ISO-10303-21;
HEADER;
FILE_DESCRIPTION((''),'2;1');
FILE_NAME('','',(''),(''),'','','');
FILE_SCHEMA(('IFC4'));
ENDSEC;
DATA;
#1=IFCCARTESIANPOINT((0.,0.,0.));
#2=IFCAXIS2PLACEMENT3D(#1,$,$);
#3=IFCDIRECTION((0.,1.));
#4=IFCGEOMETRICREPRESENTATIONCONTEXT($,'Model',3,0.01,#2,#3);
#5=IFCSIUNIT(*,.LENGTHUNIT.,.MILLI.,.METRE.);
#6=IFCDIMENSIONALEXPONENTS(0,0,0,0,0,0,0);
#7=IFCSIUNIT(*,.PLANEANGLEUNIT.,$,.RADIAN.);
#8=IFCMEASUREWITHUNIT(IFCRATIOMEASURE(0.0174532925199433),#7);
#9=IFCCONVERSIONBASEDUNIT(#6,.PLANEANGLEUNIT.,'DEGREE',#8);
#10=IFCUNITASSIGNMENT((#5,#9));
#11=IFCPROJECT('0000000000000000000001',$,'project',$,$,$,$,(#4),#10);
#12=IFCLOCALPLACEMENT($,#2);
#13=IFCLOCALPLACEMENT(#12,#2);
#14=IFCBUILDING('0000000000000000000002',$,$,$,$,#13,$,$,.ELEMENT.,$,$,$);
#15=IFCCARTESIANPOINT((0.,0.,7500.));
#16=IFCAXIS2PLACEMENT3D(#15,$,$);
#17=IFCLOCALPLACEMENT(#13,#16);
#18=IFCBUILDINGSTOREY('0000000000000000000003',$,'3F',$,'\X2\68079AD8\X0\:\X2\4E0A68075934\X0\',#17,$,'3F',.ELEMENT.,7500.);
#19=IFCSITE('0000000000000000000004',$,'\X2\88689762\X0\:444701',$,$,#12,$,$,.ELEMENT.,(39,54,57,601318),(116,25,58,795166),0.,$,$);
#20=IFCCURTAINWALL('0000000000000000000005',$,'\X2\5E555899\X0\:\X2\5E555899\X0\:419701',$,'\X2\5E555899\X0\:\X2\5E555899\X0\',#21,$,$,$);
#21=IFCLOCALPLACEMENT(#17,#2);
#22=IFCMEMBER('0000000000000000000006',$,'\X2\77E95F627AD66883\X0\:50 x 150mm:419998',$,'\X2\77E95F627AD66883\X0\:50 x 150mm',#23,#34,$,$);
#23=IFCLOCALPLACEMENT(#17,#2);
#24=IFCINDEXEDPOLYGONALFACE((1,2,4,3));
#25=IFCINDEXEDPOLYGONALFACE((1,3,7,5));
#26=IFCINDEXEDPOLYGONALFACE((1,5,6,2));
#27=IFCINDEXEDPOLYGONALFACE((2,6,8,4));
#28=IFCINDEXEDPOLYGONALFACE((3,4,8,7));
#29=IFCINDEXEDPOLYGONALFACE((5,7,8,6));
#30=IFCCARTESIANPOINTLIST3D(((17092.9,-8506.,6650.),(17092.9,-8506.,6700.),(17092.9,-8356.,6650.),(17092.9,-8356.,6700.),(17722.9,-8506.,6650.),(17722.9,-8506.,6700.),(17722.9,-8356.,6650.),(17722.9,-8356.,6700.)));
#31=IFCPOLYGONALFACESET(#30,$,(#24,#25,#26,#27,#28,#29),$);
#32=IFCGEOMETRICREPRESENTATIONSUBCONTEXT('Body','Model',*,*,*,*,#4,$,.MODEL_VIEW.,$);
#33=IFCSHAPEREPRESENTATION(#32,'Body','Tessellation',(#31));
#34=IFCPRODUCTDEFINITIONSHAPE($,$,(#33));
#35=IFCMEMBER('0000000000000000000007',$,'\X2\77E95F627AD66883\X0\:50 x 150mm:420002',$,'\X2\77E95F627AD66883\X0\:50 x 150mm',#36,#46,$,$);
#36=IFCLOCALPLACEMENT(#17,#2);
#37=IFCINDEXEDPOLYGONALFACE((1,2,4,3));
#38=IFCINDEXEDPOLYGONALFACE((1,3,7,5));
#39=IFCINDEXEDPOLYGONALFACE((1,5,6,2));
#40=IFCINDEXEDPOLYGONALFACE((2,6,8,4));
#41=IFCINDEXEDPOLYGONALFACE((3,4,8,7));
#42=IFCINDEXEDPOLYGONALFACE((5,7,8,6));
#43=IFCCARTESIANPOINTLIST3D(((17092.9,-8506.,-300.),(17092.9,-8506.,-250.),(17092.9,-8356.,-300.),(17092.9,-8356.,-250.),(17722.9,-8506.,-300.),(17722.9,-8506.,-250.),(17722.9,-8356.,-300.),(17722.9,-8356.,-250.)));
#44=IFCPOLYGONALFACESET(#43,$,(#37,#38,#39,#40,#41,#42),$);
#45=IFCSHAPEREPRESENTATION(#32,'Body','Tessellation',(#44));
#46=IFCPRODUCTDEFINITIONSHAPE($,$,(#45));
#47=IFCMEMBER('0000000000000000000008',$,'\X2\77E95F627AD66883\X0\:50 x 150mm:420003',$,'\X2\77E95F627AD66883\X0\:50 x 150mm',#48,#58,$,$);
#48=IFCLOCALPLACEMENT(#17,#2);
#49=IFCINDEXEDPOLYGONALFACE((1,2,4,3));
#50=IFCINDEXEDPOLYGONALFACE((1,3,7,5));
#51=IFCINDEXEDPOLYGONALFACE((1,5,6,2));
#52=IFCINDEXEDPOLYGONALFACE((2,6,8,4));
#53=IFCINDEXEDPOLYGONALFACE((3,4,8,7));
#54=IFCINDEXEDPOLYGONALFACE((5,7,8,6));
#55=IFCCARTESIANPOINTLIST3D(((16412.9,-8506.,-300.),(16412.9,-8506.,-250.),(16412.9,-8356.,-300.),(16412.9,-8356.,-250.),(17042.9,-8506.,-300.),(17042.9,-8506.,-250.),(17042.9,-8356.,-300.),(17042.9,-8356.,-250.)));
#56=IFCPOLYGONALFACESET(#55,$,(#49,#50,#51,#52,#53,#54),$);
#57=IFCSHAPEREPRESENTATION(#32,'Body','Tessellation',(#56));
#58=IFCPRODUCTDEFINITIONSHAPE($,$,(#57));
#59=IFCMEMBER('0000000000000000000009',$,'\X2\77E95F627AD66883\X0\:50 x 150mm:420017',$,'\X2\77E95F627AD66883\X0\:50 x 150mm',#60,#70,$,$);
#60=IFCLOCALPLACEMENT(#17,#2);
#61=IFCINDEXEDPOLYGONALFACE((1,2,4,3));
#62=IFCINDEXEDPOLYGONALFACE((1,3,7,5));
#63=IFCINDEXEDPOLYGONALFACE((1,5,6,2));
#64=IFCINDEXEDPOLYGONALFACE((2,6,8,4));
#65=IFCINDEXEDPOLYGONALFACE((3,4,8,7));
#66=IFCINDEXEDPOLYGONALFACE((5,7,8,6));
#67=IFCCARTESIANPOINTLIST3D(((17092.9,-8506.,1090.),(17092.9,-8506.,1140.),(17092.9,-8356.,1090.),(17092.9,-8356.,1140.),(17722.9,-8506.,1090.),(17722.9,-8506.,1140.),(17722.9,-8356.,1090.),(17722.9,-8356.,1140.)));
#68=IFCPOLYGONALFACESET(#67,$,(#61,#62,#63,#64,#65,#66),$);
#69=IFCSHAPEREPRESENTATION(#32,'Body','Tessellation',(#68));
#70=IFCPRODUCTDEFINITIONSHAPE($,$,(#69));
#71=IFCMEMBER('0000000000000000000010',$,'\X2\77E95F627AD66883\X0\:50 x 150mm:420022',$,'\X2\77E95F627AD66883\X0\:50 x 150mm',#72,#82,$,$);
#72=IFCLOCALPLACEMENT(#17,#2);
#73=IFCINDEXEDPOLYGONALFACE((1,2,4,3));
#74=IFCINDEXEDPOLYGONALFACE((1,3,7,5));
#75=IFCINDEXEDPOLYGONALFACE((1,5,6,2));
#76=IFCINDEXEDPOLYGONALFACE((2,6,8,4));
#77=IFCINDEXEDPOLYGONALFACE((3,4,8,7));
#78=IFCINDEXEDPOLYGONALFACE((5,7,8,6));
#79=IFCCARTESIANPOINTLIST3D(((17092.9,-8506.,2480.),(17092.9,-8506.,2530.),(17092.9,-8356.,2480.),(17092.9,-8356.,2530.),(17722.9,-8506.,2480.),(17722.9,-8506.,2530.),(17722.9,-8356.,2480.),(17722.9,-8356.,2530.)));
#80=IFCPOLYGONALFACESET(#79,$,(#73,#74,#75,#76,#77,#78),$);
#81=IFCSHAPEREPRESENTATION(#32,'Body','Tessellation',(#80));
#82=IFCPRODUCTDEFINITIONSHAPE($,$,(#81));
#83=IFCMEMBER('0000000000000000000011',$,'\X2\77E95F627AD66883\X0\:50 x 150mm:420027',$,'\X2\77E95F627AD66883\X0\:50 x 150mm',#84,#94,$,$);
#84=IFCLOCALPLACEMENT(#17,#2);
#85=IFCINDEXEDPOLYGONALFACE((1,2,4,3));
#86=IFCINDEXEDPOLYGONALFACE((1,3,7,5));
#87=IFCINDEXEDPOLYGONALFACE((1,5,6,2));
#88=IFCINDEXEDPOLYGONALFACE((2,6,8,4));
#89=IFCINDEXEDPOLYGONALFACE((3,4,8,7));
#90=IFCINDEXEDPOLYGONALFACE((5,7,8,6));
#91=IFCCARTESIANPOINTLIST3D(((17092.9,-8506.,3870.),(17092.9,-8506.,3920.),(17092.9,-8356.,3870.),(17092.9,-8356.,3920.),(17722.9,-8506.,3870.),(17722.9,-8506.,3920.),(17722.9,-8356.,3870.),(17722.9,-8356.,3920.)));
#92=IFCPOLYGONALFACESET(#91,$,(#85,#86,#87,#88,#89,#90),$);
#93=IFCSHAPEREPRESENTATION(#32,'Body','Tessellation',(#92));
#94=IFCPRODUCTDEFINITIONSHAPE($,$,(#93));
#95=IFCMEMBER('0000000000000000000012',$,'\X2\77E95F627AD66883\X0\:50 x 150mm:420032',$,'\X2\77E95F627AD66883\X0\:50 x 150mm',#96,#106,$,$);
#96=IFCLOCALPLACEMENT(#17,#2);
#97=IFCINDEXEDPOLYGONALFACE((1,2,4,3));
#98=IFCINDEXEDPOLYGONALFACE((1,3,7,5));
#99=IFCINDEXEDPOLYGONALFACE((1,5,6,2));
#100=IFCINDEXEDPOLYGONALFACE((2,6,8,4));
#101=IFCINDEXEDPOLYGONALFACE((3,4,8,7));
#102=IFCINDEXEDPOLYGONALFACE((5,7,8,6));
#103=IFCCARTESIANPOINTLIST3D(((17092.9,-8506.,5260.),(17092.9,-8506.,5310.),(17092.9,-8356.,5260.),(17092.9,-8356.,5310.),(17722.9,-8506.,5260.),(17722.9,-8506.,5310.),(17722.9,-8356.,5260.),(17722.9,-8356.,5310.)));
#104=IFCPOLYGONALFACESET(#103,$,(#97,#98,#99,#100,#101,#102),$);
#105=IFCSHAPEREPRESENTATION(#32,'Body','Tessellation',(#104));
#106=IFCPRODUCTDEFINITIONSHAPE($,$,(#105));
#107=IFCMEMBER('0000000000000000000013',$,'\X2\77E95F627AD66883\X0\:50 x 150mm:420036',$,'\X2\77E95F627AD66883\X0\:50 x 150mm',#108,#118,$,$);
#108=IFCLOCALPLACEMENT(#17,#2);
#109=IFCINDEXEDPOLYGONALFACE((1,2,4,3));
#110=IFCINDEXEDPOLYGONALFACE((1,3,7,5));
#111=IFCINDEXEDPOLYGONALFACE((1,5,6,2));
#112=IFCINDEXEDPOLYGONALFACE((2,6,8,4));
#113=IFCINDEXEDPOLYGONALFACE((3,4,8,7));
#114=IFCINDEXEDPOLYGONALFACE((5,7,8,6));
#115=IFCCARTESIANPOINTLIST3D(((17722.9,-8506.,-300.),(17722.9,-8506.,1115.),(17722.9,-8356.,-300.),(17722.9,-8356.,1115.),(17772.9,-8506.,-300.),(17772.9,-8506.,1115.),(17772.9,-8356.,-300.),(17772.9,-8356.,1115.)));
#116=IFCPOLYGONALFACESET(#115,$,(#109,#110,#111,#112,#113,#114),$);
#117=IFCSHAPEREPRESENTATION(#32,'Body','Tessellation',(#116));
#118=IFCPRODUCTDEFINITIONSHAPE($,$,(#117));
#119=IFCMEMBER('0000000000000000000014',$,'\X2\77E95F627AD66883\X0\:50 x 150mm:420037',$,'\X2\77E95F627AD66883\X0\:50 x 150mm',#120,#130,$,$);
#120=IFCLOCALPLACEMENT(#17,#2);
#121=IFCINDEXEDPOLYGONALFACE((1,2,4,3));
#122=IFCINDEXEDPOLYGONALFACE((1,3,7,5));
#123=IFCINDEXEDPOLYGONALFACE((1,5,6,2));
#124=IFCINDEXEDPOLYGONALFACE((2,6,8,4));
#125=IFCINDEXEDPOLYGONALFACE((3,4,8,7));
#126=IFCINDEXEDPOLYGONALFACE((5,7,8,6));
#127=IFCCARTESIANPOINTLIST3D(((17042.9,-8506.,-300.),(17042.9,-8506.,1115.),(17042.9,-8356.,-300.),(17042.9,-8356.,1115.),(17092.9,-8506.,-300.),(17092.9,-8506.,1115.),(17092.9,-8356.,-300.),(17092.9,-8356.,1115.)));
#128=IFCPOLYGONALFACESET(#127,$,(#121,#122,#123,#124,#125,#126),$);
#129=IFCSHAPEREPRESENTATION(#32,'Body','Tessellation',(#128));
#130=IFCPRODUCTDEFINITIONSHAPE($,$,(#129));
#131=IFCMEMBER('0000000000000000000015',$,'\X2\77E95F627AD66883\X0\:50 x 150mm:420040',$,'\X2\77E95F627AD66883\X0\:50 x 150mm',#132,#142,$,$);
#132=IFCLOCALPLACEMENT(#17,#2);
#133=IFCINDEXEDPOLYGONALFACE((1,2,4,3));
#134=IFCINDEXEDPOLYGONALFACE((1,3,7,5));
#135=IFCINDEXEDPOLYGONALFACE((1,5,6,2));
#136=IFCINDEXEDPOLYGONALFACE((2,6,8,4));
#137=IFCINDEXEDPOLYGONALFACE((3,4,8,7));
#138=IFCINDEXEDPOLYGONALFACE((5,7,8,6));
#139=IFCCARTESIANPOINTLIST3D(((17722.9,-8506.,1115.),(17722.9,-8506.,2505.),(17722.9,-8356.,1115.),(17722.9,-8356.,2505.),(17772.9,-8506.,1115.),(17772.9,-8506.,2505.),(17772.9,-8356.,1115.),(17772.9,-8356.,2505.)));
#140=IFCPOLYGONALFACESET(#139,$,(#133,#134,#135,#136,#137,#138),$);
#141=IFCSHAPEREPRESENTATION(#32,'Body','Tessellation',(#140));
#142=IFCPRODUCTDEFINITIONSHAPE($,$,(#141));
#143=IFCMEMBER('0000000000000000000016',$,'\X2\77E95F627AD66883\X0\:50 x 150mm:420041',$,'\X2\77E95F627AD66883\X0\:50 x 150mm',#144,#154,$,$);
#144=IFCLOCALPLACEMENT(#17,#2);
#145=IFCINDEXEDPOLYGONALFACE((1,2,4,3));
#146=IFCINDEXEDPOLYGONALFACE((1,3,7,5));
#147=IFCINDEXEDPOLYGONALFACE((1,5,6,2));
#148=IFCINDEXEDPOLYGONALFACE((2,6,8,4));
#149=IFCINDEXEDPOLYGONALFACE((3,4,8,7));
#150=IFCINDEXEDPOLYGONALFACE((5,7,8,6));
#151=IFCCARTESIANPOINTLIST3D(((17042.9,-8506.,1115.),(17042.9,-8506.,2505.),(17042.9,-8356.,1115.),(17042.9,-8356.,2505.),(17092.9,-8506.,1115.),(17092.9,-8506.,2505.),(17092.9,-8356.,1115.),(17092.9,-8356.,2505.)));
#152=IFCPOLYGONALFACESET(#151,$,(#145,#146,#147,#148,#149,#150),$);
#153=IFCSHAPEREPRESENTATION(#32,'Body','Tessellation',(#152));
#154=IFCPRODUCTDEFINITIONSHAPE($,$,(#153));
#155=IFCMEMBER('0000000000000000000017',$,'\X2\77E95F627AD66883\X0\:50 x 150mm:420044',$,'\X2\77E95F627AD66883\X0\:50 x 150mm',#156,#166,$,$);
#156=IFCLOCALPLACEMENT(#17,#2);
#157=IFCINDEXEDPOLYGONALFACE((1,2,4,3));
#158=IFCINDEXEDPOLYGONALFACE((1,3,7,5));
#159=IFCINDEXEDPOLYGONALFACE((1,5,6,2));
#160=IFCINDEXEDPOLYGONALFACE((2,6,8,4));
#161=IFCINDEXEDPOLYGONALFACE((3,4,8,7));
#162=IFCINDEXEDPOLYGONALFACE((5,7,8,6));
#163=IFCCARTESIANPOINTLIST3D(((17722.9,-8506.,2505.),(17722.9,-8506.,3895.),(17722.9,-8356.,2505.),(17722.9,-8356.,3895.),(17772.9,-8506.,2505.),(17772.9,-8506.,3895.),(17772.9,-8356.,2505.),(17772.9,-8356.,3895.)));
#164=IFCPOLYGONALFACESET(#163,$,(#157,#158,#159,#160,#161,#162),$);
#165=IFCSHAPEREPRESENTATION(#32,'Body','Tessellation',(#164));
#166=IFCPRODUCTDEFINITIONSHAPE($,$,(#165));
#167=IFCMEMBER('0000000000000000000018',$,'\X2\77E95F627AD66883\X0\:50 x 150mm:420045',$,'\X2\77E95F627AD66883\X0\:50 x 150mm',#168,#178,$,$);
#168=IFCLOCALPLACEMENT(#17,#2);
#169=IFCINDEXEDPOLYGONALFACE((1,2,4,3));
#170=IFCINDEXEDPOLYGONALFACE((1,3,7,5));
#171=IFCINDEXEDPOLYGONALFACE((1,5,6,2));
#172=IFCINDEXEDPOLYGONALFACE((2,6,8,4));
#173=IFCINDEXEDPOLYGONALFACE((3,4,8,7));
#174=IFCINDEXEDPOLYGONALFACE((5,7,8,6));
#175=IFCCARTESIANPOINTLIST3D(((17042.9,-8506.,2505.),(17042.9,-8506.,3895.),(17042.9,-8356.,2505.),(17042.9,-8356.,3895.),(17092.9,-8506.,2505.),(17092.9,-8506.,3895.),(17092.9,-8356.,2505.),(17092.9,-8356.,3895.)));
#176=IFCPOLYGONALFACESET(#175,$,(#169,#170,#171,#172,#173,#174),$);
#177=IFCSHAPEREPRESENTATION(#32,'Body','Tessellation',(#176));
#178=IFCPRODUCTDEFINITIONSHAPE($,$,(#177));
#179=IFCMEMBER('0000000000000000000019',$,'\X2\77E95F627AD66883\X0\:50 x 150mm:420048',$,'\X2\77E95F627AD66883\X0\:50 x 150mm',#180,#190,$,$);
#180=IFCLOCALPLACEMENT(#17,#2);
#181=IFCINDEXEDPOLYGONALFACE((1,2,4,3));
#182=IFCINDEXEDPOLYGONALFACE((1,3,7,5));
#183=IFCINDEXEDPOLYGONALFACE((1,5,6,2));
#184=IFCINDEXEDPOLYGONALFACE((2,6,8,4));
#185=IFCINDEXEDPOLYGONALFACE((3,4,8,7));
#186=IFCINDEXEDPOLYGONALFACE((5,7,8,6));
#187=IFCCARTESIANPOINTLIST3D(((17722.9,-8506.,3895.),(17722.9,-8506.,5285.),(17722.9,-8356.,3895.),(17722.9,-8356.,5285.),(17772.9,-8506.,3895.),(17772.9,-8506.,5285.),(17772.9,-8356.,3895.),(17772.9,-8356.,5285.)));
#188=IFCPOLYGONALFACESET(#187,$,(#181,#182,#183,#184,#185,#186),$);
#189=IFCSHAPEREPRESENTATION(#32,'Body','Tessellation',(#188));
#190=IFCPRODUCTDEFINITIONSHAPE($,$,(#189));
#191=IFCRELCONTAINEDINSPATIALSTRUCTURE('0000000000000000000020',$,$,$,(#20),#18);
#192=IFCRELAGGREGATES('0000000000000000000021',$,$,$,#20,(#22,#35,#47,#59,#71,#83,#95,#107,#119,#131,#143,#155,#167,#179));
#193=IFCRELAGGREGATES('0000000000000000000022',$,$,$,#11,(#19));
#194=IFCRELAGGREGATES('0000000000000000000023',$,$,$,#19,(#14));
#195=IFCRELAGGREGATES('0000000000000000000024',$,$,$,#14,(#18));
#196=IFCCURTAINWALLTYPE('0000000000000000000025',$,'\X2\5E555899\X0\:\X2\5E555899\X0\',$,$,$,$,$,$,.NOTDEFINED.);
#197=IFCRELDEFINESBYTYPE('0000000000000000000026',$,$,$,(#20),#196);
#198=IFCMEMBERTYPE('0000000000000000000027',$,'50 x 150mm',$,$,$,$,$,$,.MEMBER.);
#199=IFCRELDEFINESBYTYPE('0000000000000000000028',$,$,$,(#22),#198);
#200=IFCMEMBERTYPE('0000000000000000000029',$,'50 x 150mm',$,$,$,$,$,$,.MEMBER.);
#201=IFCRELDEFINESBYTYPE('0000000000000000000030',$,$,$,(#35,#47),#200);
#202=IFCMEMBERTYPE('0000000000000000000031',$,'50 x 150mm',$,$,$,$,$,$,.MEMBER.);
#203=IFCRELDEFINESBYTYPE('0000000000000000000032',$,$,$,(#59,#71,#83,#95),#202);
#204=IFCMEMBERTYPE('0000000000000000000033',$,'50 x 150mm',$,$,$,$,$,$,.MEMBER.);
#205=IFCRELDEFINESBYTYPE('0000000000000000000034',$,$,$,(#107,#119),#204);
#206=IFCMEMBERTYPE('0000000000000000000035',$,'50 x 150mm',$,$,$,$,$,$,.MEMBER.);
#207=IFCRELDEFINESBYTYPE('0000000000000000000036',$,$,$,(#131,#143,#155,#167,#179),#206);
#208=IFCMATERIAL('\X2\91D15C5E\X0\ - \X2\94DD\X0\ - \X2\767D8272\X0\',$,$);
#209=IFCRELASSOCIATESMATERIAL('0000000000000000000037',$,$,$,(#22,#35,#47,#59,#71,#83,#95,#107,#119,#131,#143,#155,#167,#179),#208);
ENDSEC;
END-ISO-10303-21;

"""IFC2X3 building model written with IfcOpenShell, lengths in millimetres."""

from ifc_helpers import new_model, entity, si_unit, converted_unit, direction, frame, origin, origin_2d_with_axis, place, context, subcontext, project, spatial, rectangle, extrude, source, transform, mapped, material, type_object, type_shapes, element, aggregate, save


model = new_model("IFC2X3")

# Units and contexts
model_context = context("Model", 3, precision=0.01, world=origin(), true_north=direction((0.0, 1.0)))
body_context = subcontext(model_context, "Body", "Model", "MODEL_VIEW")
ifc_project = project(units=[si_unit("LENGTHUNIT", "METRE", prefix="MILLI"), converted_unit("PLANEANGLEUNIT", "DEGREE", entity("IfcRatioMeasure", 0.0174532925199433), si_unit("PLANEANGLEUNIT", "RADIAN"), dimensions=[0, 0, 0, 0, 0, 0, 0])], contexts=[model_context])

# Site, building, storey
site_placement = place(None, origin())
site = spatial("IfcSite", under=ifc_project, at=site_placement, Name="表面:444701", CompositionType="ELEMENT", RefLatitude=(39, 54, 57, 601318), RefLongitude=(116, 25, 58, 795166), RefElevation=0.0)
building_placement = place(site_placement, origin())
building = spatial("IfcBuilding", under=site, at=building_placement, CompositionType="ELEMENT")
storey_placement = place(building_placement, frame((0.0, 0.0, 7500.0)))
storey = spatial("IfcBuildingStorey", under=building, at=storey_placement, Name="3F", ObjectType="标高:上标头", LongName="3F", CompositionType="ELEMENT", Elevation=7500.0)

# Curtain wall, members
curtain_wall_type = type_object("IfcCurtainWallType", Name="幕墙:幕墙", PredefinedType="NOTDEFINED")
curtain_wall_placement = place(storey_placement, frame((0.0, 0.0, -7500.0)))
curtain_wall = element("IfcCurtainWall", 1, at=curtain_wall_placement, inside=storey, type_object=curtain_wall_type, Name="幕墙:幕墙:419701", ObjectType="幕墙:幕墙")
ifc_material_1 = material(Name="金属 - 铝 - 白色")
member_type_1 = type_object("IfcMemberType", Name="50 x 150mm", PredefinedType="MEMBER")
shared_shape_1 = source(origin(), body_context, "Body", "SweptSolid", [
    extrude(rectangle(XDim=150.0, YDim=50.0, at=origin_2d_with_axis()), frame((-25.0, 0.0, -630.0), z_axis=(0.0, 0.0, 1.0), x_axis=(0.0, -1.0, 0.0)), (0.0, 0.0, 1.0), 630.0),
])
type_shapes(member_type_1, [shared_shape_1])
member_1_placement = place(storey_placement, frame((17092.9, -8431.0, 6700.0), z_axis=(-1.0, 0.0, 0.0), x_axis=(0.0, 0.0, 1.0)))
member_1 = element("IfcMember", 2, at=member_1_placement, type_object=member_type_1, material=ifc_material_1, Name="矩形竖梃:50 x 150mm:419998", ObjectType="矩形竖梃:50 x 150mm", context=body_context, shape_type="MappedRepresentation", body=[
    mapped(shared_shape_1, transform((0.0, 0.0, 0.0), scale=1.0)),
])
member_type_2 = type_object("IfcMemberType", Name="50 x 150mm", PredefinedType="MEMBER")
shared_shape_2 = source(origin(), body_context, "Body", "SweptSolid", [
    extrude(rectangle(XDim=150.0, YDim=50.0, at=origin_2d_with_axis()), frame((-25.0, 0.0, -630.0), z_axis=(0.0, 0.0, 1.0), x_axis=(0.0, -1.0, 0.0)), (0.0, 0.0, 1.0), 630.0),
])
type_shapes(member_type_2, [shared_shape_2])
member_2_placement = place(storey_placement, frame((17722.9, -8431.0, -300.0), z_axis=(1.0, 0.0, 0.0), x_axis=(0.0, 0.0, -1.0)))
member_2 = element("IfcMember", 3, at=member_2_placement, type_object=member_type_2, material=ifc_material_1, Name="矩形竖梃:50 x 150mm:420002", ObjectType="矩形竖梃:50 x 150mm", context=body_context, shape_type="MappedRepresentation", body=[
    mapped(shared_shape_2, transform((0.0, 0.0, 0.0), scale=1.0)),
])
member_3_placement = place(storey_placement, frame((17042.9, -8431.0, -300.0), z_axis=(1.0, 0.0, 0.0), x_axis=(0.0, 0.0, -1.0)))
member_3 = element("IfcMember", 4, at=member_3_placement, type_object=member_type_2, material=ifc_material_1, Name="矩形竖梃:50 x 150mm:420003", ObjectType="矩形竖梃:50 x 150mm", context=body_context, shape_type="MappedRepresentation", body=[
    mapped(shared_shape_2, transform((0.0, 0.0, 0.0), scale=1.0)),
])
member_type_3 = type_object("IfcMemberType", Name="50 x 150mm", PredefinedType="MEMBER")
shared_shape_3 = source(origin(), body_context, "Body", "SweptSolid", [
    extrude(rectangle(XDim=150.0, YDim=50.0, at=origin_2d_with_axis()), frame((0.0, 0.0, -630.0), z_axis=(0.0, 0.0, 1.0), x_axis=(0.0, -1.0, 0.0)), (0.0, 0.0, 1.0), 630.0),
])
type_shapes(member_type_3, [shared_shape_3])
member_4_placement = place(storey_placement, frame((17092.9, -8431.0, 1115.0), z_axis=(-1.0, 0.0, 0.0), x_axis=(0.0, 0.0, 1.0)))
member_4 = element("IfcMember", 5, at=member_4_placement, type_object=member_type_3, material=ifc_material_1, Name="矩形竖梃:50 x 150mm:420017", ObjectType="矩形竖梃:50 x 150mm", context=body_context, shape_type="MappedRepresentation", body=[
    mapped(shared_shape_3, transform((0.0, 0.0, 0.0), scale=1.0)),
])
member_5_placement = place(storey_placement, frame((17092.9, -8431.0, 2505.0), z_axis=(-1.0, 0.0, 0.0), x_axis=(0.0, 0.0, 1.0)))
member_5 = element("IfcMember", 6, at=member_5_placement, type_object=member_type_3, material=ifc_material_1, Name="矩形竖梃:50 x 150mm:420022", ObjectType="矩形竖梃:50 x 150mm", context=body_context, shape_type="MappedRepresentation", body=[
    mapped(shared_shape_3, transform((0.0, 0.0, 0.0), scale=1.0)),
])
member_6_placement = place(storey_placement, frame((17092.9, -8431.0, 3895.0), z_axis=(-1.0, 0.0, 0.0), x_axis=(0.0, 0.0, 1.0)))
member_6 = element("IfcMember", 7, at=member_6_placement, type_object=member_type_3, material=ifc_material_1, Name="矩形竖梃:50 x 150mm:420027", ObjectType="矩形竖梃:50 x 150mm", context=body_context, shape_type="MappedRepresentation", body=[
    mapped(shared_shape_3, transform((0.0, 0.0, 0.0), scale=1.0)),
])
member_7_placement = place(storey_placement, frame((17092.9, -8431.0, 5285.0), z_axis=(-1.0, 0.0, 0.0), x_axis=(0.0, 0.0, 1.0)))
member_7 = element("IfcMember", 8, at=member_7_placement, type_object=member_type_3, material=ifc_material_1, Name="矩形竖梃:50 x 150mm:420032", ObjectType="矩形竖梃:50 x 150mm", context=body_context, shape_type="MappedRepresentation", body=[
    mapped(shared_shape_3, transform((0.0, 0.0, 0.0), scale=1.0)),
])
member_type_4 = type_object("IfcMemberType", Name="50 x 150mm", PredefinedType="MEMBER")
shared_shape_4 = source(origin(), body_context, "Body", "SweptSolid", [
    extrude(rectangle(XDim=150.0, YDim=50.0, at=origin_2d_with_axis()), frame((0.0, 0.0, -1415.0), z_axis=(0.0, 0.0, 1.0), x_axis=(0.0, -1.0, 0.0)), (0.0, 0.0, 1.0), 1415.0),
])
type_shapes(member_type_4, [shared_shape_4])
member_8_placement = place(storey_placement, frame((17747.9, -8431.0, -300.0), z_axis=(0.0, 0.0, -1.0), x_axis=(-1.0, 0.0, 0.0)))
member_8 = element("IfcMember", 9, at=member_8_placement, type_object=member_type_4, material=ifc_material_1, Name="矩形竖梃:50 x 150mm:420036", ObjectType="矩形竖梃:50 x 150mm", context=body_context, shape_type="MappedRepresentation", body=[
    mapped(shared_shape_4, transform((0.0, 0.0, 0.0), scale=1.0)),
])
member_9_placement = place(storey_placement, frame((17067.9, -8431.0, -300.0), z_axis=(0.0, 0.0, -1.0), x_axis=(-1.0, 0.0, 0.0)))
member_9 = element("IfcMember", 10, at=member_9_placement, type_object=member_type_4, material=ifc_material_1, Name="矩形竖梃:50 x 150mm:420037", ObjectType="矩形竖梃:50 x 150mm", context=body_context, shape_type="MappedRepresentation", body=[
    mapped(shared_shape_4, transform((0.0, 0.0, 0.0), scale=1.0)),
])
member_type_5 = type_object("IfcMemberType", Name="50 x 150mm", PredefinedType="MEMBER")
shared_shape_5 = source(origin(), body_context, "Body", "SweptSolid", [
    extrude(rectangle(XDim=150.0, YDim=50.0, at=origin_2d_with_axis()), frame((0.0, 0.0, -1390.0), z_axis=(0.0, 0.0, 1.0), x_axis=(0.0, -1.0, 0.0)), (0.0, 0.0, 1.0), 1390.0),
])
type_shapes(member_type_5, [shared_shape_5])
member_10_placement = place(storey_placement, frame((17747.9, -8431.0, 1115.0), z_axis=(0.0, 0.0, -1.0), x_axis=(-1.0, 0.0, 0.0)))
member_10 = element("IfcMember", 11, at=member_10_placement, type_object=member_type_5, material=ifc_material_1, Name="矩形竖梃:50 x 150mm:420040", ObjectType="矩形竖梃:50 x 150mm", context=body_context, shape_type="MappedRepresentation", body=[
    mapped(shared_shape_5, transform((0.0, 0.0, 0.0), scale=1.0)),
])
member_11_placement = place(storey_placement, frame((17067.9, -8431.0, 1115.0), z_axis=(0.0, 0.0, -1.0), x_axis=(-1.0, 0.0, 0.0)))
member_11 = element("IfcMember", 12, at=member_11_placement, type_object=member_type_5, material=ifc_material_1, Name="矩形竖梃:50 x 150mm:420041", ObjectType="矩形竖梃:50 x 150mm", context=body_context, shape_type="MappedRepresentation", body=[
    mapped(shared_shape_5, transform((0.0, 0.0, 0.0), scale=1.0)),
])
member_12_placement = place(storey_placement, frame((17747.9, -8431.0, 2505.0), z_axis=(0.0, 0.0, -1.0), x_axis=(-1.0, 0.0, 0.0)))
member_12 = element("IfcMember", 13, at=member_12_placement, type_object=member_type_5, material=ifc_material_1, Name="矩形竖梃:50 x 150mm:420044", ObjectType="矩形竖梃:50 x 150mm", context=body_context, shape_type="MappedRepresentation", body=[
    mapped(shared_shape_5, transform((0.0, 0.0, 0.0), scale=1.0)),
])
member_13_placement = place(storey_placement, frame((17067.9, -8431.0, 2505.0), z_axis=(0.0, 0.0, -1.0), x_axis=(-1.0, 0.0, 0.0)))
member_13 = element("IfcMember", 14, at=member_13_placement, type_object=member_type_5, material=ifc_material_1, Name="矩形竖梃:50 x 150mm:420045", ObjectType="矩形竖梃:50 x 150mm", context=body_context, shape_type="MappedRepresentation", body=[
    mapped(shared_shape_5, transform((0.0, 0.0, 0.0), scale=1.0)),
])
member_14_placement = place(storey_placement, frame((17747.9, -8431.0, 3895.0), z_axis=(0.0, 0.0, -1.0), x_axis=(-1.0, 0.0, 0.0)))
member_14 = element("IfcMember", 15, at=member_14_placement, type_object=member_type_5, material=ifc_material_1, Name="矩形竖梃:50 x 150mm:420048", ObjectType="矩形竖梃:50 x 150mm", context=body_context, shape_type="MappedRepresentation", body=[
    mapped(shared_shape_5, transform((0.0, 0.0, 0.0), scale=1.0)),
])
aggregate(curtain_wall, [member_1, member_2, member_3, member_4, member_5, member_6, member_7, member_8, member_9, member_10, member_11, member_12, member_13, member_14])

save(model, "model.ifc")
